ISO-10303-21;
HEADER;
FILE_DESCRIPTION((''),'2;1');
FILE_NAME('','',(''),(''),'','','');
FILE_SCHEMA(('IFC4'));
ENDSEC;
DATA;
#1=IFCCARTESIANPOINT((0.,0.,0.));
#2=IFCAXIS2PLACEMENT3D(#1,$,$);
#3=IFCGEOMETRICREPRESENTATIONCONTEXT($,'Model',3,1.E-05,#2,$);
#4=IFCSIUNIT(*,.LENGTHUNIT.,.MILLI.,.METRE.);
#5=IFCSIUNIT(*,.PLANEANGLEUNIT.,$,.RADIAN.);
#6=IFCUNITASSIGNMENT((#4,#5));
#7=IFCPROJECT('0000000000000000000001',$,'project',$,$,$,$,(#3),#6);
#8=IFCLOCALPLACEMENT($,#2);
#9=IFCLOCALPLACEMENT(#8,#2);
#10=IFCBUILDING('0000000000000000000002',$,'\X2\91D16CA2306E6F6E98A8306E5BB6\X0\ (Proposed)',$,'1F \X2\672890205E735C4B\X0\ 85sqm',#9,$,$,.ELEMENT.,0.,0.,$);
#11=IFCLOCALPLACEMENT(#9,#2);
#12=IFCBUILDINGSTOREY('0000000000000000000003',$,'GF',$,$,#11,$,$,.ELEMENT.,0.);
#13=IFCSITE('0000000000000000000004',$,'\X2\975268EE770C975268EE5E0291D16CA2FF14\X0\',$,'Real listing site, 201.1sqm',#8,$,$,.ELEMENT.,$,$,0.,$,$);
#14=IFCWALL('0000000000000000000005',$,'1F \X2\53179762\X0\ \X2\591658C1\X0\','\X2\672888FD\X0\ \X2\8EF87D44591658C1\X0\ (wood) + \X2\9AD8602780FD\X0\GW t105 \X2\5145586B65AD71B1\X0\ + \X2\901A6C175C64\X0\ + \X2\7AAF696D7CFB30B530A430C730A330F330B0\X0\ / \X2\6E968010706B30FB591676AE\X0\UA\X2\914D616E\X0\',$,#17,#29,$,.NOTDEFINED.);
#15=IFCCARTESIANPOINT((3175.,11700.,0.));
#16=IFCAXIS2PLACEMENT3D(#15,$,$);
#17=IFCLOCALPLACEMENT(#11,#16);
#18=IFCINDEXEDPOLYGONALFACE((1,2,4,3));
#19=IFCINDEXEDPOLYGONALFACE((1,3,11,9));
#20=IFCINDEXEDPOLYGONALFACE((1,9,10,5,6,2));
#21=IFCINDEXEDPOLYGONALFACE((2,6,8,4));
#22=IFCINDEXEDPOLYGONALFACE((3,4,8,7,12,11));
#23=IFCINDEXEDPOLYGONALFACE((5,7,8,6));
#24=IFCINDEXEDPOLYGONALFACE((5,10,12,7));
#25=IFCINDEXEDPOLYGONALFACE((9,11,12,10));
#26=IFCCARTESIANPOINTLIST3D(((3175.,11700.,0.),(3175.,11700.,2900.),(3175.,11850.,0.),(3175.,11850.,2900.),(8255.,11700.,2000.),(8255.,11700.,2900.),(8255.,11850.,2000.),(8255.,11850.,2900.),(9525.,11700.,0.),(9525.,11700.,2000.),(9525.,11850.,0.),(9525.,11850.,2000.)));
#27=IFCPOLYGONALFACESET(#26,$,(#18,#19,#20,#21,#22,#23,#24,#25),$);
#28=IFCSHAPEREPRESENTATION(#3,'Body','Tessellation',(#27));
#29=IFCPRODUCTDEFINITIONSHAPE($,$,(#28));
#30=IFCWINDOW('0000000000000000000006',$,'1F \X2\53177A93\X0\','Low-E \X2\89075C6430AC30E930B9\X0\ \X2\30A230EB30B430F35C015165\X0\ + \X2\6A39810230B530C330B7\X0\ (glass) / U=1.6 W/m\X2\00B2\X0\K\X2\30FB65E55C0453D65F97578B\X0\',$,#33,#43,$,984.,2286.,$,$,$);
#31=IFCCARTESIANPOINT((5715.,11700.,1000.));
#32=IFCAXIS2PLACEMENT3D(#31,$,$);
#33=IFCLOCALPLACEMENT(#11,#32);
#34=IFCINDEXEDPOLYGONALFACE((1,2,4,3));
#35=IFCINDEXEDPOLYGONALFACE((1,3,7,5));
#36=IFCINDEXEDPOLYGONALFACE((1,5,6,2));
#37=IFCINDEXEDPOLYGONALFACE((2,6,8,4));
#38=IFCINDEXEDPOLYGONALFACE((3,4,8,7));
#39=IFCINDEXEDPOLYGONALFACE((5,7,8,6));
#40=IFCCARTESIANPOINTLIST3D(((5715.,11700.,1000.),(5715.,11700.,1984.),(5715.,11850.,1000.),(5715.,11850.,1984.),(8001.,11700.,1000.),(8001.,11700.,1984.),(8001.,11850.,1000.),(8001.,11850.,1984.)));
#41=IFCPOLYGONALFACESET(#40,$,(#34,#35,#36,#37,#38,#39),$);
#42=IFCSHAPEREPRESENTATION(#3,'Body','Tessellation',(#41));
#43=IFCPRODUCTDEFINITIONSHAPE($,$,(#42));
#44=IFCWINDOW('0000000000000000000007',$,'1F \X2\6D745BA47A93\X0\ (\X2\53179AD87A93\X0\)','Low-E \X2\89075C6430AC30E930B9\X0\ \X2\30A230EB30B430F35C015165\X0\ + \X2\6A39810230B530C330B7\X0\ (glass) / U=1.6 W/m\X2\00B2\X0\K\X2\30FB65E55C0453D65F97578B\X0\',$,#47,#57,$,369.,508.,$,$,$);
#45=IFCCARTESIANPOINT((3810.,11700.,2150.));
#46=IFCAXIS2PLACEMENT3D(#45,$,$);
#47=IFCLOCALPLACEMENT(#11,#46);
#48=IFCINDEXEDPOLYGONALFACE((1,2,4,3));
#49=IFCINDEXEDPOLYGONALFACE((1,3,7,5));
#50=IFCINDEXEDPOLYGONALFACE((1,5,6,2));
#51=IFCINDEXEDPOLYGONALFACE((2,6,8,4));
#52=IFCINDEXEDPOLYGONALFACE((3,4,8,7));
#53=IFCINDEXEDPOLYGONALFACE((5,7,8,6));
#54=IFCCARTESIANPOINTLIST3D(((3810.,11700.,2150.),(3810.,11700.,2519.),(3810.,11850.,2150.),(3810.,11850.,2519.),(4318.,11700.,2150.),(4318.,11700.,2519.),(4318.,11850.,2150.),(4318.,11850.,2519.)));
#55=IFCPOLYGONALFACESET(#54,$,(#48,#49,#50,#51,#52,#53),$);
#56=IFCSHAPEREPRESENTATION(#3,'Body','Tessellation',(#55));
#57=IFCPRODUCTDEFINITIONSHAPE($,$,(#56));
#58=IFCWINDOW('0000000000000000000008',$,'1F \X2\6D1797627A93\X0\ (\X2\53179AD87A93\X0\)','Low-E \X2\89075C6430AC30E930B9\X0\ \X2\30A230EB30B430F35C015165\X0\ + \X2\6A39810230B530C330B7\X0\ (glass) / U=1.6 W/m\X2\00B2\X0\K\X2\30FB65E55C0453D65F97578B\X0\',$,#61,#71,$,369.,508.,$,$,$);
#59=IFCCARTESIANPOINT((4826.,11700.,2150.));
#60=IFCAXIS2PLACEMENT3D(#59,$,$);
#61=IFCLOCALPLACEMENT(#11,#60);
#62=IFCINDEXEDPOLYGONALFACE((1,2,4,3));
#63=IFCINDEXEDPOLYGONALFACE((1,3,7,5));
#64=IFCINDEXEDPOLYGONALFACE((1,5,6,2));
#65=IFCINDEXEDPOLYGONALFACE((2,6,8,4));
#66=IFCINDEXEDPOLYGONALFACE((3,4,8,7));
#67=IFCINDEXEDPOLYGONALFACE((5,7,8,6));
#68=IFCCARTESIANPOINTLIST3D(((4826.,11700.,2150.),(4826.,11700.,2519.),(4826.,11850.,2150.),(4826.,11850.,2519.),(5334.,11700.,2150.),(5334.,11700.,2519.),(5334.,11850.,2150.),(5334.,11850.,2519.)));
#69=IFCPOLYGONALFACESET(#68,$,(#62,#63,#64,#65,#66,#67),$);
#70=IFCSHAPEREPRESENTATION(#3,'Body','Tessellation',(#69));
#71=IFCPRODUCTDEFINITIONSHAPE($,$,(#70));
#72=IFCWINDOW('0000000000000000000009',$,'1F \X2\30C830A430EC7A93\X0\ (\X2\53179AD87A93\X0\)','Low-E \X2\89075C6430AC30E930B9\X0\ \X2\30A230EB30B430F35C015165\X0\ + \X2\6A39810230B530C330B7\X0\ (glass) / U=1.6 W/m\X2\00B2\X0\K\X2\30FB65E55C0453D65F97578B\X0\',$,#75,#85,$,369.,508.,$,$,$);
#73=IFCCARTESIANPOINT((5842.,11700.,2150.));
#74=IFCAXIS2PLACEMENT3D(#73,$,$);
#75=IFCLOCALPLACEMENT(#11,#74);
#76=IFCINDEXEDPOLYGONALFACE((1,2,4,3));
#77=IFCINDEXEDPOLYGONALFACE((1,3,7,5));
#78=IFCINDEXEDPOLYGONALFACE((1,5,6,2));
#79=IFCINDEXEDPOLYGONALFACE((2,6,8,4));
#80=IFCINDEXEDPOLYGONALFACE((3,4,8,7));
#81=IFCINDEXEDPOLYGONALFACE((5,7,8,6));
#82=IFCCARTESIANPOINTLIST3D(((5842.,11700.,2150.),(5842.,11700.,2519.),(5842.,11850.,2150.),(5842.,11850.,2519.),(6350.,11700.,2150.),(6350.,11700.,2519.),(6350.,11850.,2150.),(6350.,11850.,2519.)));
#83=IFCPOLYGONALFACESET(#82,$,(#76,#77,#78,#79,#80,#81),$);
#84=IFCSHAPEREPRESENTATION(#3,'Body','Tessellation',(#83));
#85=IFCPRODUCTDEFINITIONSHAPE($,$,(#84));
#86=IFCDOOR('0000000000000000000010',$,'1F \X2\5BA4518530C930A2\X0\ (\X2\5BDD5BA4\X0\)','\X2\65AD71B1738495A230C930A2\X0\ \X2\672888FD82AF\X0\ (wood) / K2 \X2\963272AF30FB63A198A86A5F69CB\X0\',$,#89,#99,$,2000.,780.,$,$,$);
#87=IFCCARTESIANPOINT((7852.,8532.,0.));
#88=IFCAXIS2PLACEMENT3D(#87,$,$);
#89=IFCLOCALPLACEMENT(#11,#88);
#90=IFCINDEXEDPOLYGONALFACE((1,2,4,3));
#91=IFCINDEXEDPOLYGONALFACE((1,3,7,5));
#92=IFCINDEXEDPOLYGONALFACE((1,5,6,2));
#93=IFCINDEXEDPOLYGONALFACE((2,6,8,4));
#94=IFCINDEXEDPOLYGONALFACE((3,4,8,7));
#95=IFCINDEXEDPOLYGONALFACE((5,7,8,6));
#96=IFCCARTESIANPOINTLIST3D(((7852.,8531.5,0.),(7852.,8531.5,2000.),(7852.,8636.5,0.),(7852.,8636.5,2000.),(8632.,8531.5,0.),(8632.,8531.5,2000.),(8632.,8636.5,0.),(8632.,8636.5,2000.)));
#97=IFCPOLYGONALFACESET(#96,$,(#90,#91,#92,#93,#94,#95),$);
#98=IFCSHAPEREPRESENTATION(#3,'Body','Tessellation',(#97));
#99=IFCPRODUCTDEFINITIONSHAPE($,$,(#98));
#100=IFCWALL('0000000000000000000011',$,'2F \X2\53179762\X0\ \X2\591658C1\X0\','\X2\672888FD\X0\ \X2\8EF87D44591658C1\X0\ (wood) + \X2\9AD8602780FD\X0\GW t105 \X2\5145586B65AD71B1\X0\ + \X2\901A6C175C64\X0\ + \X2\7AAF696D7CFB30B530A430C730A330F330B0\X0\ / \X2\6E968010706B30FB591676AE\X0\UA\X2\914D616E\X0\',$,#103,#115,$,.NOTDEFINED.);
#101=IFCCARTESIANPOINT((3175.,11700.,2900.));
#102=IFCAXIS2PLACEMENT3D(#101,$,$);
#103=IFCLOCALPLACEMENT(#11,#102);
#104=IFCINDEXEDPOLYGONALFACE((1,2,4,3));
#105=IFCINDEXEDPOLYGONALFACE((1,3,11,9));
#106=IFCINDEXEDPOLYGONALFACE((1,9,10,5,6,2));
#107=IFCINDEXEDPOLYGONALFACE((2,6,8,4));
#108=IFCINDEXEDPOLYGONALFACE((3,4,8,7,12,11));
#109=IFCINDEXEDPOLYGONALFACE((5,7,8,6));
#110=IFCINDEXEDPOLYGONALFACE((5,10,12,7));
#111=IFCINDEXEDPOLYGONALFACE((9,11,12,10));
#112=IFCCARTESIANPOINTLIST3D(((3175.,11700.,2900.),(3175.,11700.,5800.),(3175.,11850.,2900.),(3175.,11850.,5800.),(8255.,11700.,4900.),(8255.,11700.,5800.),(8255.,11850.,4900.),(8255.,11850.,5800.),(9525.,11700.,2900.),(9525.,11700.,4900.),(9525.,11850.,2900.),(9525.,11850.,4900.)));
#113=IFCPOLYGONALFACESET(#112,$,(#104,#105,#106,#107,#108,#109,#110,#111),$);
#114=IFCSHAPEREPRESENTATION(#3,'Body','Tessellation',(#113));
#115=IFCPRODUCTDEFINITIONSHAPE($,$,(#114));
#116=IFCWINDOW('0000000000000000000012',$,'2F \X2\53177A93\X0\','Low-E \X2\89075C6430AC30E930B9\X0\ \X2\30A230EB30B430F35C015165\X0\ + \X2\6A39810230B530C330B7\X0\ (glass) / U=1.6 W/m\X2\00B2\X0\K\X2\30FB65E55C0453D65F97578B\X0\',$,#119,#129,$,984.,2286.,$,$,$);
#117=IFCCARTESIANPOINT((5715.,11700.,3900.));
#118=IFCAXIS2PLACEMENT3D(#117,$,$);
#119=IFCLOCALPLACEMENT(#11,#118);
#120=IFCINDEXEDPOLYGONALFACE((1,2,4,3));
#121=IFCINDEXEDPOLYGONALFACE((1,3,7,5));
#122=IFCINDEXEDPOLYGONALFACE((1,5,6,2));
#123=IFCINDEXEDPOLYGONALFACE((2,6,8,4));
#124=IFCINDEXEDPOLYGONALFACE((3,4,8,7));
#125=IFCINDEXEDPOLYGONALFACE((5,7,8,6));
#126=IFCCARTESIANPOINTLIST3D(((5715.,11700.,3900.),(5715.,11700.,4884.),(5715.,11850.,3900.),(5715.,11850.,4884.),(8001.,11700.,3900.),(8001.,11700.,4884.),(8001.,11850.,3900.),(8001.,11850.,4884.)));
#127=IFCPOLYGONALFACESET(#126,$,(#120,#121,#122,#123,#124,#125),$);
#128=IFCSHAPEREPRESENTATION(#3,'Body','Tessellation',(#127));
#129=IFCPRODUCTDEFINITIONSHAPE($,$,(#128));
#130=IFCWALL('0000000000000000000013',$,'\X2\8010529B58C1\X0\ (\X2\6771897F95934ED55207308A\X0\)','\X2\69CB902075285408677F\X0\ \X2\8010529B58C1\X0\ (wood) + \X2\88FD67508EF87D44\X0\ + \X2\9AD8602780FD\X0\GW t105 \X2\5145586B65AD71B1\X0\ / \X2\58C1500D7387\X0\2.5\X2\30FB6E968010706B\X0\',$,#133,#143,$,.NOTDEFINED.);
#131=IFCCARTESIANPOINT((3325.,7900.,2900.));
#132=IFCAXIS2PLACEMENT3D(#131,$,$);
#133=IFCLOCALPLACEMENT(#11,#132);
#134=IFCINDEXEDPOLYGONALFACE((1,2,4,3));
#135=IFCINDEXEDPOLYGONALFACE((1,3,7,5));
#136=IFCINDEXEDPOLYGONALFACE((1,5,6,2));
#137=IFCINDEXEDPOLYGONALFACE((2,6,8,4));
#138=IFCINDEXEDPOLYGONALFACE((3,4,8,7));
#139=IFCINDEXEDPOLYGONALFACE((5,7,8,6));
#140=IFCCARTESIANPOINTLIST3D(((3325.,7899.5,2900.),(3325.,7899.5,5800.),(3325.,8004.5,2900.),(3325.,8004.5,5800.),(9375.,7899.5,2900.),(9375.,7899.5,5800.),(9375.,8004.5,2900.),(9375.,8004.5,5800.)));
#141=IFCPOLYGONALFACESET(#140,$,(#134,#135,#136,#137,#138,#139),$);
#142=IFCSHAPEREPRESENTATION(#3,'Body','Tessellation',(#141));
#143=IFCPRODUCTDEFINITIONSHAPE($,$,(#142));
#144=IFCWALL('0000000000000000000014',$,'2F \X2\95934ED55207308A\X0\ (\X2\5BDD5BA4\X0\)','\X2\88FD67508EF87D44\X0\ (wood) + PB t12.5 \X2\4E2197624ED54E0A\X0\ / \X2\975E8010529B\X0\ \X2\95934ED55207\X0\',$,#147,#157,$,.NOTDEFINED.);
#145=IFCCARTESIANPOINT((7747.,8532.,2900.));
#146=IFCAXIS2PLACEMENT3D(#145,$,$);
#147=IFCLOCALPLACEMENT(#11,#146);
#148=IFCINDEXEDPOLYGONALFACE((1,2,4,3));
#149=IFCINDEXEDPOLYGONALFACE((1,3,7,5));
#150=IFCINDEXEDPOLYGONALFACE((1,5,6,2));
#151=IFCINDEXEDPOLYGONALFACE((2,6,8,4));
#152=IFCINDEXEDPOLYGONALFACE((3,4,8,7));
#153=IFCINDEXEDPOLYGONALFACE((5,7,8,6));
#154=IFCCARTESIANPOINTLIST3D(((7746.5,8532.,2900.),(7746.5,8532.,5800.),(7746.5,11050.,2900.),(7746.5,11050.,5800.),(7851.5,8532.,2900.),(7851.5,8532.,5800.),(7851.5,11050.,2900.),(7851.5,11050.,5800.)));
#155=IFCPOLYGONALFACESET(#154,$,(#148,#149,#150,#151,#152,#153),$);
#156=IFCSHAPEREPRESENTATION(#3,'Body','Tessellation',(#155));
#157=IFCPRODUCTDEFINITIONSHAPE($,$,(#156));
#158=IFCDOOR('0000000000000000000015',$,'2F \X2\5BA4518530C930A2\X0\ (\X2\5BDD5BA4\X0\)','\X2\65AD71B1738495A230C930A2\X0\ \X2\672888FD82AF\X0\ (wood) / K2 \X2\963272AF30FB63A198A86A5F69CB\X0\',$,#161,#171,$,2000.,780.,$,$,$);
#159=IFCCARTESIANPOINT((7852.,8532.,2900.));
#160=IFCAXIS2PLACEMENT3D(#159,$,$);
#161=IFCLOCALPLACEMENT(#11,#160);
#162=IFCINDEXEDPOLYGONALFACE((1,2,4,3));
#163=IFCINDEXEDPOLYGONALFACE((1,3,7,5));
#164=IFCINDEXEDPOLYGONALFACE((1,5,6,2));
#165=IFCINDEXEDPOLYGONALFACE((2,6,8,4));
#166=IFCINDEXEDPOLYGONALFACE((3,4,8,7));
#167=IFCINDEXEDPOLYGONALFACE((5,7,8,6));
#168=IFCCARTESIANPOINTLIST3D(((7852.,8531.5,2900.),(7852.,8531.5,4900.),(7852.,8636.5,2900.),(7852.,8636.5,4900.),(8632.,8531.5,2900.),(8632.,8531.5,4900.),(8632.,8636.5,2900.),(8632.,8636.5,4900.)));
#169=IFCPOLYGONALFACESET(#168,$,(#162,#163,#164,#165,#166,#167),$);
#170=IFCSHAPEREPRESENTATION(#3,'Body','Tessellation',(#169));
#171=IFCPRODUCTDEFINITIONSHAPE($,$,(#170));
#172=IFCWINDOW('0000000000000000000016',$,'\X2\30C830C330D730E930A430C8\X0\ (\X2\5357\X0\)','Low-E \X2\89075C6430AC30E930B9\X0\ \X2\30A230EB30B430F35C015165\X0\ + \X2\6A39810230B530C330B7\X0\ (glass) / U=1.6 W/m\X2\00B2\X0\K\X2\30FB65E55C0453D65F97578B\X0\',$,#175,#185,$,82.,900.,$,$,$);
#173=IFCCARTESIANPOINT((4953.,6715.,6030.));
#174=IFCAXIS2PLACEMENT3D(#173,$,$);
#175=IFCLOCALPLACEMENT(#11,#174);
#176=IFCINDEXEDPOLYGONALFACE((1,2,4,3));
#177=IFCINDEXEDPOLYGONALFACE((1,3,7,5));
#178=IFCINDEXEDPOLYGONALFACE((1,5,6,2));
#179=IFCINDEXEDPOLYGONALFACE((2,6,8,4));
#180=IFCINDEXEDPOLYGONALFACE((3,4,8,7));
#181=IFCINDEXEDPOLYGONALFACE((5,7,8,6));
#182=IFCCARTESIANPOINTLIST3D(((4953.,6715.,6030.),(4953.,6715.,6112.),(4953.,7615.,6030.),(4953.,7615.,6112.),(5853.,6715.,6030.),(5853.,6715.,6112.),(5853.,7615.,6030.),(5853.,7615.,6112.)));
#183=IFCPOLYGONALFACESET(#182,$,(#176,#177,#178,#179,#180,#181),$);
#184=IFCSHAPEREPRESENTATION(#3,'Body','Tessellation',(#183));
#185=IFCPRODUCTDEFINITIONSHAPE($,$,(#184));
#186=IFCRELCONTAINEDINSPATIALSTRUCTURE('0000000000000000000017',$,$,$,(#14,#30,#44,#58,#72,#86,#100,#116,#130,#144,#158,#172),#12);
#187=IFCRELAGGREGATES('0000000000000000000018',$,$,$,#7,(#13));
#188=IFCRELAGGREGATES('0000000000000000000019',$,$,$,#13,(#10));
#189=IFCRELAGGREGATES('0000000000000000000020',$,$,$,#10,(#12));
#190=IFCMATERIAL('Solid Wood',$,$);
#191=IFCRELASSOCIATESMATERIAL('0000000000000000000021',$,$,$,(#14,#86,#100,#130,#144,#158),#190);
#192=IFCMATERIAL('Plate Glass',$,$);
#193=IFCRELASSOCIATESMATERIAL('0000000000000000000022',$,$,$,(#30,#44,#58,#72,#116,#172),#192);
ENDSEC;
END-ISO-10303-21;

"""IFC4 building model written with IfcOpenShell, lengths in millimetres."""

from ifc_helpers import new_model, si_unit, frame, frame_2d, origin, place, context, project, spatial, rectangle, extrude, material, element, fill, save


model = new_model("IFC4")

# Units and contexts
model_context = context("Model", 3, precision=1e-05, world=origin())
ifc_project = project(units=[si_unit("LENGTHUNIT", "METRE", prefix="MILLI"), si_unit("PLANEANGLEUNIT", "RADIAN")], contexts=[model_context])

# Site, building, storey
site_placement = place(None, origin())
site = spatial("IfcSite", under=ifc_project, at=site_placement, Name="青森県青森市金沢４", ObjectType="Real listing site, 201.1sqm", CompositionType="ELEMENT", RefElevation=0.0)
building_placement = place(site_placement, origin())
building = spatial("IfcBuilding", under=site, at=building_placement, Name="金沢の潮風の家 (Proposed)", ObjectType="1F 木造平屋 85sqm", CompositionType="ELEMENT", ElevationOfRefHeight=0.0, ElevationOfTerrain=0.0)
storey_placement = place(building_placement, origin())
storey = spatial("IfcBuildingStorey", under=building, at=storey_placement, Name="GF", CompositionType="ELEMENT", Elevation=0.0)

# Wall, openings, windows
ifc_material_1 = material(Name="Solid Wood")
wall_1_placement = place(storey_placement, frame((3175.0, 11700.0, 0.0)))
wall_1 = element("IfcWall", 1, at=wall_1_placement, inside=storey, material=ifc_material_1, Name="1F 北面 外壁", Description="木製 軸組外壁 (wood) + 高性能GW t105 充填断熱 + 通気層 + 窯業系サイディング / 準耐火・外皮UA配慮", PredefinedType="NOTDEFINED", context=model_context, shape_type="SweptSolid", body=[
    extrude(rectangle(XDim=6350.0, YDim=150.0, at=frame_2d((3175.0, 75.0))), frame((3175.0, 11700.0, 0.0)), (0.0, 0.0, 1.0), 2900.0),
])
opening_1_placement = place(storey_placement, frame((5715.0, 11700.0, 1000.0)))
opening_1 = element("IfcOpeningElement", 2, at=opening_1_placement, cuts=wall_1, PredefinedType="NOTDEFINED", context=model_context, shape_type="SweptSolid", body=[
    extrude(rectangle(XDim=2286.0, YDim=150.0, at=frame_2d((1143.0, 75.0))), frame((5715.0, 11700.0, 1000.0)), (0.0, 0.0, 1.0), 984.0),
])
opening_2_placement = place(storey_placement, frame((3810.0, 11700.0, 2150.0)))
opening_2 = element("IfcOpeningElement", 3, at=opening_2_placement, cuts=wall_1, PredefinedType="NOTDEFINED", context=model_context, shape_type="SweptSolid", body=[
    extrude(rectangle(XDim=508.0, YDim=150.0, at=frame_2d((254.0, 75.0))), frame((3810.0, 11700.0, 2150.0)), (0.0, 0.0, 1.0), 369.0),
])
opening_3_placement = place(storey_placement, frame((4826.0, 11700.0, 2150.0)))
opening_3 = element("IfcOpeningElement", 4, at=opening_3_placement, cuts=wall_1, PredefinedType="NOTDEFINED", context=model_context, shape_type="SweptSolid", body=[
    extrude(rectangle(XDim=508.0, YDim=150.0, at=frame_2d((254.0, 75.0))), frame((4826.0, 11700.0, 2150.0)), (0.0, 0.0, 1.0), 369.0),
])
opening_4_placement = place(storey_placement, frame((5842.0, 11700.0, 2150.0)))
opening_4 = element("IfcOpeningElement", 5, at=opening_4_placement, cuts=wall_1, PredefinedType="NOTDEFINED", context=model_context, shape_type="SweptSolid", body=[
    extrude(rectangle(XDim=508.0, YDim=150.0, at=frame_2d((254.0, 75.0))), frame((5842.0, 11700.0, 2150.0)), (0.0, 0.0, 1.0), 369.0),
])
ifc_material_2 = material(Name="Plate Glass")
window_1_placement = place(storey_placement, frame((5715.0, 11700.0, 1000.0)))
window_1 = element("IfcWindow", 6, at=window_1_placement, inside=storey, material=ifc_material_2, Name="1F 北窓", Description="Low-E 複層ガラス アルゴン封入 + 樹脂サッシ (glass) / U=1.6 W/m²K・日射取得型", OverallHeight=984.0, OverallWidth=2286.0, context=model_context, shape_type="SweptSolid", body=[
    extrude(rectangle(XDim=2286.0, YDim=150.0, at=frame_2d((1143.0, 75.0))), frame((5715.0, 11700.0, 1000.0)), (0.0, 0.0, 1.0), 984.0),
])
fill(opening_1, window_1)
window_2_placement = place(storey_placement, frame((3810.0, 11700.0, 2150.0)))
window_2 = element("IfcWindow", 7, at=window_2_placement, inside=storey, material=ifc_material_2, Name="1F 浴室窓 (北高窓)", Description="Low-E 複層ガラス アルゴン封入 + 樹脂サッシ (glass) / U=1.6 W/m²K・日射取得型", OverallHeight=369.0, OverallWidth=508.0, context=model_context, shape_type="SweptSolid", body=[
    extrude(rectangle(XDim=508.0, YDim=150.0, at=frame_2d((254.0, 75.0))), frame((3810.0, 11700.0, 2150.0)), (0.0, 0.0, 1.0), 369.0),
])
fill(opening_2, window_2)
window_3_placement = place(storey_placement, frame((4826.0, 11700.0, 2150.0)))
window_3 = element("IfcWindow", 8, at=window_3_placement, inside=storey, material=ifc_material_2, Name="1F 洗面窓 (北高窓)", Description="Low-E 複層ガラス アルゴン封入 + 樹脂サッシ (glass) / U=1.6 W/m²K・日射取得型", OverallHeight=369.0, OverallWidth=508.0, context=model_context, shape_type="SweptSolid", body=[
    extrude(rectangle(XDim=508.0, YDim=150.0, at=frame_2d((254.0, 75.0))), frame((4826.0, 11700.0, 2150.0)), (0.0, 0.0, 1.0), 369.0),
])
fill(opening_3, window_3)
window_4_placement = place(storey_placement, frame((5842.0, 11700.0, 2150.0)))
window_4 = element("IfcWindow", 9, at=window_4_placement, inside=storey, material=ifc_material_2, Name="1F トイレ窓 (北高窓)", Description="Low-E 複層ガラス アルゴン封入 + 樹脂サッシ (glass) / U=1.6 W/m²K・日射取得型", OverallHeight=369.0, OverallWidth=508.0, context=model_context, shape_type="SweptSolid", body=[
    extrude(rectangle(XDim=508.0, YDim=150.0, at=frame_2d((254.0, 75.0))), frame((5842.0, 11700.0, 2150.0)), (0.0, 0.0, 1.0), 369.0),
])
fill(opening_4, window_4)

# Door
door_1_placement = place(storey_placement, frame((7852.0, 8532.0, 0.0)))
element("IfcDoor", 10, at=door_1_placement, inside=storey, material=ifc_material_1, Name="1F 室内ドア (寝室)", Description="断熱玄関ドア 木製芯 (wood) / K2 防犯・採風機構", OverallHeight=2000.0, OverallWidth=780.0, context=model_context, shape_type="SweptSolid", body=[
    extrude(rectangle(XDim=780.0, YDim=105.0, at=frame_2d((390.0, 52.0))), frame((7852.0, 8532.0, 0.0)), (0.0, 0.0, 1.0), 2000.0),
])

# Wall, opening, window
wall_2_placement = place(storey_placement, frame((3175.0, 11700.0, 2900.0)))
wall_2 = element("IfcWall", 11, at=wall_2_placement, inside=storey, material=ifc_material_1, Name="2F 北面 外壁", Description="木製 軸組外壁 (wood) + 高性能GW t105 充填断熱 + 通気層 + 窯業系サイディング / 準耐火・外皮UA配慮", PredefinedType="NOTDEFINED", context=model_context, shape_type="SweptSolid", body=[
    extrude(rectangle(XDim=6350.0, YDim=150.0, at=frame_2d((3175.0, 75.0))), frame((3175.0, 11700.0, 2900.0)), (0.0, 0.0, 1.0), 2900.0),
])
opening_5_placement = place(storey_placement, frame((5715.0, 11700.0, 3900.0)))
opening_5 = element("IfcOpeningElement", 12, at=opening_5_placement, cuts=wall_2, PredefinedType="NOTDEFINED", context=model_context, shape_type="SweptSolid", body=[
    extrude(rectangle(XDim=2286.0, YDim=150.0, at=frame_2d((1143.0, 75.0))), frame((5715.0, 11700.0, 3900.0)), (0.0, 0.0, 1.0), 984.0),
])
window_5_placement = place(storey_placement, frame((5715.0, 11700.0, 3900.0)))
window_5 = element("IfcWindow", 13, at=window_5_placement, inside=storey, material=ifc_material_2, Name="2F 北窓", Description="Low-E 複層ガラス アルゴン封入 + 樹脂サッシ (glass) / U=1.6 W/m²K・日射取得型", OverallHeight=984.0, OverallWidth=2286.0, context=model_context, shape_type="SweptSolid", body=[
    extrude(rectangle(XDim=2286.0, YDim=150.0, at=frame_2d((1143.0, 75.0))), frame((5715.0, 11700.0, 3900.0)), (0.0, 0.0, 1.0), 984.0),
])
fill(opening_5, window_5)

# Walls
wall_3_placement = place(storey_placement, frame((3325.0, 7900.0, 2900.0)))
element("IfcWall", 14, at=wall_3_placement, inside=storey, material=ifc_material_1, Name="耐力壁 (東西間仕切り)", Description="構造用合板 耐力壁 (wood) + 製材軸組 + 高性能GW t105 充填断熱 / 壁倍率2.5・準耐火", PredefinedType="NOTDEFINED", context=model_context, shape_type="SweptSolid", body=[
    extrude(rectangle(XDim=6050.0, YDim=105.0, at=frame_2d((3025.0, 52.0))), frame((3325.0, 7900.0, 2900.0)), (0.0, 0.0, 1.0), 2900.0),
])
wall_4_placement = place(storey_placement, frame((7747.0, 8532.0, 2900.0)))
element("IfcWall", 15, at=wall_4_placement, inside=storey, material=ifc_material_1, Name="2F 間仕切り (寝室)", Description="製材軸組 (wood) + PB t12.5 両面仕上 / 非耐力 間仕切", PredefinedType="NOTDEFINED", context=model_context, shape_type="SweptSolid", body=[
    extrude(rectangle(XDim=105.0, YDim=2518.0, at=frame_2d((52.0, 1259.0))), frame((7747.0, 8532.0, 2900.0)), (0.0, 0.0, 1.0), 2900.0),
])

# Door
door_2_placement = place(storey_placement, frame((7852.0, 8532.0, 2900.0)))
element("IfcDoor", 16, at=door_2_placement, inside=storey, material=ifc_material_1, Name="2F 室内ドア (寝室)", Description="断熱玄関ドア 木製芯 (wood) / K2 防犯・採風機構", OverallHeight=2000.0, OverallWidth=780.0, context=model_context, shape_type="SweptSolid", body=[
    extrude(rectangle(XDim=780.0, YDim=105.0, at=frame_2d((390.0, 52.0))), frame((7852.0, 8532.0, 2900.0)), (0.0, 0.0, 1.0), 2000.0),
])

# Window
window_6_placement = place(storey_placement, frame((4953.0, 6715.0, 6030.0)))
element("IfcWindow", 17, at=window_6_placement, inside=storey, material=ifc_material_2, Name="トップライト (南)", Description="Low-E 複層ガラス アルゴン封入 + 樹脂サッシ (glass) / U=1.6 W/m²K・日射取得型", OverallHeight=82.0, OverallWidth=900.0, context=model_context, shape_type="SweptSolid", body=[
    extrude(rectangle(XDim=900.0, YDim=900.0, at=frame_2d((450.0, 450.0))), frame((4953.0, 6715.0, 6030.0)), (0.0, 0.0, 1.0), 82.0),
])

save(model, "model.ifc")
